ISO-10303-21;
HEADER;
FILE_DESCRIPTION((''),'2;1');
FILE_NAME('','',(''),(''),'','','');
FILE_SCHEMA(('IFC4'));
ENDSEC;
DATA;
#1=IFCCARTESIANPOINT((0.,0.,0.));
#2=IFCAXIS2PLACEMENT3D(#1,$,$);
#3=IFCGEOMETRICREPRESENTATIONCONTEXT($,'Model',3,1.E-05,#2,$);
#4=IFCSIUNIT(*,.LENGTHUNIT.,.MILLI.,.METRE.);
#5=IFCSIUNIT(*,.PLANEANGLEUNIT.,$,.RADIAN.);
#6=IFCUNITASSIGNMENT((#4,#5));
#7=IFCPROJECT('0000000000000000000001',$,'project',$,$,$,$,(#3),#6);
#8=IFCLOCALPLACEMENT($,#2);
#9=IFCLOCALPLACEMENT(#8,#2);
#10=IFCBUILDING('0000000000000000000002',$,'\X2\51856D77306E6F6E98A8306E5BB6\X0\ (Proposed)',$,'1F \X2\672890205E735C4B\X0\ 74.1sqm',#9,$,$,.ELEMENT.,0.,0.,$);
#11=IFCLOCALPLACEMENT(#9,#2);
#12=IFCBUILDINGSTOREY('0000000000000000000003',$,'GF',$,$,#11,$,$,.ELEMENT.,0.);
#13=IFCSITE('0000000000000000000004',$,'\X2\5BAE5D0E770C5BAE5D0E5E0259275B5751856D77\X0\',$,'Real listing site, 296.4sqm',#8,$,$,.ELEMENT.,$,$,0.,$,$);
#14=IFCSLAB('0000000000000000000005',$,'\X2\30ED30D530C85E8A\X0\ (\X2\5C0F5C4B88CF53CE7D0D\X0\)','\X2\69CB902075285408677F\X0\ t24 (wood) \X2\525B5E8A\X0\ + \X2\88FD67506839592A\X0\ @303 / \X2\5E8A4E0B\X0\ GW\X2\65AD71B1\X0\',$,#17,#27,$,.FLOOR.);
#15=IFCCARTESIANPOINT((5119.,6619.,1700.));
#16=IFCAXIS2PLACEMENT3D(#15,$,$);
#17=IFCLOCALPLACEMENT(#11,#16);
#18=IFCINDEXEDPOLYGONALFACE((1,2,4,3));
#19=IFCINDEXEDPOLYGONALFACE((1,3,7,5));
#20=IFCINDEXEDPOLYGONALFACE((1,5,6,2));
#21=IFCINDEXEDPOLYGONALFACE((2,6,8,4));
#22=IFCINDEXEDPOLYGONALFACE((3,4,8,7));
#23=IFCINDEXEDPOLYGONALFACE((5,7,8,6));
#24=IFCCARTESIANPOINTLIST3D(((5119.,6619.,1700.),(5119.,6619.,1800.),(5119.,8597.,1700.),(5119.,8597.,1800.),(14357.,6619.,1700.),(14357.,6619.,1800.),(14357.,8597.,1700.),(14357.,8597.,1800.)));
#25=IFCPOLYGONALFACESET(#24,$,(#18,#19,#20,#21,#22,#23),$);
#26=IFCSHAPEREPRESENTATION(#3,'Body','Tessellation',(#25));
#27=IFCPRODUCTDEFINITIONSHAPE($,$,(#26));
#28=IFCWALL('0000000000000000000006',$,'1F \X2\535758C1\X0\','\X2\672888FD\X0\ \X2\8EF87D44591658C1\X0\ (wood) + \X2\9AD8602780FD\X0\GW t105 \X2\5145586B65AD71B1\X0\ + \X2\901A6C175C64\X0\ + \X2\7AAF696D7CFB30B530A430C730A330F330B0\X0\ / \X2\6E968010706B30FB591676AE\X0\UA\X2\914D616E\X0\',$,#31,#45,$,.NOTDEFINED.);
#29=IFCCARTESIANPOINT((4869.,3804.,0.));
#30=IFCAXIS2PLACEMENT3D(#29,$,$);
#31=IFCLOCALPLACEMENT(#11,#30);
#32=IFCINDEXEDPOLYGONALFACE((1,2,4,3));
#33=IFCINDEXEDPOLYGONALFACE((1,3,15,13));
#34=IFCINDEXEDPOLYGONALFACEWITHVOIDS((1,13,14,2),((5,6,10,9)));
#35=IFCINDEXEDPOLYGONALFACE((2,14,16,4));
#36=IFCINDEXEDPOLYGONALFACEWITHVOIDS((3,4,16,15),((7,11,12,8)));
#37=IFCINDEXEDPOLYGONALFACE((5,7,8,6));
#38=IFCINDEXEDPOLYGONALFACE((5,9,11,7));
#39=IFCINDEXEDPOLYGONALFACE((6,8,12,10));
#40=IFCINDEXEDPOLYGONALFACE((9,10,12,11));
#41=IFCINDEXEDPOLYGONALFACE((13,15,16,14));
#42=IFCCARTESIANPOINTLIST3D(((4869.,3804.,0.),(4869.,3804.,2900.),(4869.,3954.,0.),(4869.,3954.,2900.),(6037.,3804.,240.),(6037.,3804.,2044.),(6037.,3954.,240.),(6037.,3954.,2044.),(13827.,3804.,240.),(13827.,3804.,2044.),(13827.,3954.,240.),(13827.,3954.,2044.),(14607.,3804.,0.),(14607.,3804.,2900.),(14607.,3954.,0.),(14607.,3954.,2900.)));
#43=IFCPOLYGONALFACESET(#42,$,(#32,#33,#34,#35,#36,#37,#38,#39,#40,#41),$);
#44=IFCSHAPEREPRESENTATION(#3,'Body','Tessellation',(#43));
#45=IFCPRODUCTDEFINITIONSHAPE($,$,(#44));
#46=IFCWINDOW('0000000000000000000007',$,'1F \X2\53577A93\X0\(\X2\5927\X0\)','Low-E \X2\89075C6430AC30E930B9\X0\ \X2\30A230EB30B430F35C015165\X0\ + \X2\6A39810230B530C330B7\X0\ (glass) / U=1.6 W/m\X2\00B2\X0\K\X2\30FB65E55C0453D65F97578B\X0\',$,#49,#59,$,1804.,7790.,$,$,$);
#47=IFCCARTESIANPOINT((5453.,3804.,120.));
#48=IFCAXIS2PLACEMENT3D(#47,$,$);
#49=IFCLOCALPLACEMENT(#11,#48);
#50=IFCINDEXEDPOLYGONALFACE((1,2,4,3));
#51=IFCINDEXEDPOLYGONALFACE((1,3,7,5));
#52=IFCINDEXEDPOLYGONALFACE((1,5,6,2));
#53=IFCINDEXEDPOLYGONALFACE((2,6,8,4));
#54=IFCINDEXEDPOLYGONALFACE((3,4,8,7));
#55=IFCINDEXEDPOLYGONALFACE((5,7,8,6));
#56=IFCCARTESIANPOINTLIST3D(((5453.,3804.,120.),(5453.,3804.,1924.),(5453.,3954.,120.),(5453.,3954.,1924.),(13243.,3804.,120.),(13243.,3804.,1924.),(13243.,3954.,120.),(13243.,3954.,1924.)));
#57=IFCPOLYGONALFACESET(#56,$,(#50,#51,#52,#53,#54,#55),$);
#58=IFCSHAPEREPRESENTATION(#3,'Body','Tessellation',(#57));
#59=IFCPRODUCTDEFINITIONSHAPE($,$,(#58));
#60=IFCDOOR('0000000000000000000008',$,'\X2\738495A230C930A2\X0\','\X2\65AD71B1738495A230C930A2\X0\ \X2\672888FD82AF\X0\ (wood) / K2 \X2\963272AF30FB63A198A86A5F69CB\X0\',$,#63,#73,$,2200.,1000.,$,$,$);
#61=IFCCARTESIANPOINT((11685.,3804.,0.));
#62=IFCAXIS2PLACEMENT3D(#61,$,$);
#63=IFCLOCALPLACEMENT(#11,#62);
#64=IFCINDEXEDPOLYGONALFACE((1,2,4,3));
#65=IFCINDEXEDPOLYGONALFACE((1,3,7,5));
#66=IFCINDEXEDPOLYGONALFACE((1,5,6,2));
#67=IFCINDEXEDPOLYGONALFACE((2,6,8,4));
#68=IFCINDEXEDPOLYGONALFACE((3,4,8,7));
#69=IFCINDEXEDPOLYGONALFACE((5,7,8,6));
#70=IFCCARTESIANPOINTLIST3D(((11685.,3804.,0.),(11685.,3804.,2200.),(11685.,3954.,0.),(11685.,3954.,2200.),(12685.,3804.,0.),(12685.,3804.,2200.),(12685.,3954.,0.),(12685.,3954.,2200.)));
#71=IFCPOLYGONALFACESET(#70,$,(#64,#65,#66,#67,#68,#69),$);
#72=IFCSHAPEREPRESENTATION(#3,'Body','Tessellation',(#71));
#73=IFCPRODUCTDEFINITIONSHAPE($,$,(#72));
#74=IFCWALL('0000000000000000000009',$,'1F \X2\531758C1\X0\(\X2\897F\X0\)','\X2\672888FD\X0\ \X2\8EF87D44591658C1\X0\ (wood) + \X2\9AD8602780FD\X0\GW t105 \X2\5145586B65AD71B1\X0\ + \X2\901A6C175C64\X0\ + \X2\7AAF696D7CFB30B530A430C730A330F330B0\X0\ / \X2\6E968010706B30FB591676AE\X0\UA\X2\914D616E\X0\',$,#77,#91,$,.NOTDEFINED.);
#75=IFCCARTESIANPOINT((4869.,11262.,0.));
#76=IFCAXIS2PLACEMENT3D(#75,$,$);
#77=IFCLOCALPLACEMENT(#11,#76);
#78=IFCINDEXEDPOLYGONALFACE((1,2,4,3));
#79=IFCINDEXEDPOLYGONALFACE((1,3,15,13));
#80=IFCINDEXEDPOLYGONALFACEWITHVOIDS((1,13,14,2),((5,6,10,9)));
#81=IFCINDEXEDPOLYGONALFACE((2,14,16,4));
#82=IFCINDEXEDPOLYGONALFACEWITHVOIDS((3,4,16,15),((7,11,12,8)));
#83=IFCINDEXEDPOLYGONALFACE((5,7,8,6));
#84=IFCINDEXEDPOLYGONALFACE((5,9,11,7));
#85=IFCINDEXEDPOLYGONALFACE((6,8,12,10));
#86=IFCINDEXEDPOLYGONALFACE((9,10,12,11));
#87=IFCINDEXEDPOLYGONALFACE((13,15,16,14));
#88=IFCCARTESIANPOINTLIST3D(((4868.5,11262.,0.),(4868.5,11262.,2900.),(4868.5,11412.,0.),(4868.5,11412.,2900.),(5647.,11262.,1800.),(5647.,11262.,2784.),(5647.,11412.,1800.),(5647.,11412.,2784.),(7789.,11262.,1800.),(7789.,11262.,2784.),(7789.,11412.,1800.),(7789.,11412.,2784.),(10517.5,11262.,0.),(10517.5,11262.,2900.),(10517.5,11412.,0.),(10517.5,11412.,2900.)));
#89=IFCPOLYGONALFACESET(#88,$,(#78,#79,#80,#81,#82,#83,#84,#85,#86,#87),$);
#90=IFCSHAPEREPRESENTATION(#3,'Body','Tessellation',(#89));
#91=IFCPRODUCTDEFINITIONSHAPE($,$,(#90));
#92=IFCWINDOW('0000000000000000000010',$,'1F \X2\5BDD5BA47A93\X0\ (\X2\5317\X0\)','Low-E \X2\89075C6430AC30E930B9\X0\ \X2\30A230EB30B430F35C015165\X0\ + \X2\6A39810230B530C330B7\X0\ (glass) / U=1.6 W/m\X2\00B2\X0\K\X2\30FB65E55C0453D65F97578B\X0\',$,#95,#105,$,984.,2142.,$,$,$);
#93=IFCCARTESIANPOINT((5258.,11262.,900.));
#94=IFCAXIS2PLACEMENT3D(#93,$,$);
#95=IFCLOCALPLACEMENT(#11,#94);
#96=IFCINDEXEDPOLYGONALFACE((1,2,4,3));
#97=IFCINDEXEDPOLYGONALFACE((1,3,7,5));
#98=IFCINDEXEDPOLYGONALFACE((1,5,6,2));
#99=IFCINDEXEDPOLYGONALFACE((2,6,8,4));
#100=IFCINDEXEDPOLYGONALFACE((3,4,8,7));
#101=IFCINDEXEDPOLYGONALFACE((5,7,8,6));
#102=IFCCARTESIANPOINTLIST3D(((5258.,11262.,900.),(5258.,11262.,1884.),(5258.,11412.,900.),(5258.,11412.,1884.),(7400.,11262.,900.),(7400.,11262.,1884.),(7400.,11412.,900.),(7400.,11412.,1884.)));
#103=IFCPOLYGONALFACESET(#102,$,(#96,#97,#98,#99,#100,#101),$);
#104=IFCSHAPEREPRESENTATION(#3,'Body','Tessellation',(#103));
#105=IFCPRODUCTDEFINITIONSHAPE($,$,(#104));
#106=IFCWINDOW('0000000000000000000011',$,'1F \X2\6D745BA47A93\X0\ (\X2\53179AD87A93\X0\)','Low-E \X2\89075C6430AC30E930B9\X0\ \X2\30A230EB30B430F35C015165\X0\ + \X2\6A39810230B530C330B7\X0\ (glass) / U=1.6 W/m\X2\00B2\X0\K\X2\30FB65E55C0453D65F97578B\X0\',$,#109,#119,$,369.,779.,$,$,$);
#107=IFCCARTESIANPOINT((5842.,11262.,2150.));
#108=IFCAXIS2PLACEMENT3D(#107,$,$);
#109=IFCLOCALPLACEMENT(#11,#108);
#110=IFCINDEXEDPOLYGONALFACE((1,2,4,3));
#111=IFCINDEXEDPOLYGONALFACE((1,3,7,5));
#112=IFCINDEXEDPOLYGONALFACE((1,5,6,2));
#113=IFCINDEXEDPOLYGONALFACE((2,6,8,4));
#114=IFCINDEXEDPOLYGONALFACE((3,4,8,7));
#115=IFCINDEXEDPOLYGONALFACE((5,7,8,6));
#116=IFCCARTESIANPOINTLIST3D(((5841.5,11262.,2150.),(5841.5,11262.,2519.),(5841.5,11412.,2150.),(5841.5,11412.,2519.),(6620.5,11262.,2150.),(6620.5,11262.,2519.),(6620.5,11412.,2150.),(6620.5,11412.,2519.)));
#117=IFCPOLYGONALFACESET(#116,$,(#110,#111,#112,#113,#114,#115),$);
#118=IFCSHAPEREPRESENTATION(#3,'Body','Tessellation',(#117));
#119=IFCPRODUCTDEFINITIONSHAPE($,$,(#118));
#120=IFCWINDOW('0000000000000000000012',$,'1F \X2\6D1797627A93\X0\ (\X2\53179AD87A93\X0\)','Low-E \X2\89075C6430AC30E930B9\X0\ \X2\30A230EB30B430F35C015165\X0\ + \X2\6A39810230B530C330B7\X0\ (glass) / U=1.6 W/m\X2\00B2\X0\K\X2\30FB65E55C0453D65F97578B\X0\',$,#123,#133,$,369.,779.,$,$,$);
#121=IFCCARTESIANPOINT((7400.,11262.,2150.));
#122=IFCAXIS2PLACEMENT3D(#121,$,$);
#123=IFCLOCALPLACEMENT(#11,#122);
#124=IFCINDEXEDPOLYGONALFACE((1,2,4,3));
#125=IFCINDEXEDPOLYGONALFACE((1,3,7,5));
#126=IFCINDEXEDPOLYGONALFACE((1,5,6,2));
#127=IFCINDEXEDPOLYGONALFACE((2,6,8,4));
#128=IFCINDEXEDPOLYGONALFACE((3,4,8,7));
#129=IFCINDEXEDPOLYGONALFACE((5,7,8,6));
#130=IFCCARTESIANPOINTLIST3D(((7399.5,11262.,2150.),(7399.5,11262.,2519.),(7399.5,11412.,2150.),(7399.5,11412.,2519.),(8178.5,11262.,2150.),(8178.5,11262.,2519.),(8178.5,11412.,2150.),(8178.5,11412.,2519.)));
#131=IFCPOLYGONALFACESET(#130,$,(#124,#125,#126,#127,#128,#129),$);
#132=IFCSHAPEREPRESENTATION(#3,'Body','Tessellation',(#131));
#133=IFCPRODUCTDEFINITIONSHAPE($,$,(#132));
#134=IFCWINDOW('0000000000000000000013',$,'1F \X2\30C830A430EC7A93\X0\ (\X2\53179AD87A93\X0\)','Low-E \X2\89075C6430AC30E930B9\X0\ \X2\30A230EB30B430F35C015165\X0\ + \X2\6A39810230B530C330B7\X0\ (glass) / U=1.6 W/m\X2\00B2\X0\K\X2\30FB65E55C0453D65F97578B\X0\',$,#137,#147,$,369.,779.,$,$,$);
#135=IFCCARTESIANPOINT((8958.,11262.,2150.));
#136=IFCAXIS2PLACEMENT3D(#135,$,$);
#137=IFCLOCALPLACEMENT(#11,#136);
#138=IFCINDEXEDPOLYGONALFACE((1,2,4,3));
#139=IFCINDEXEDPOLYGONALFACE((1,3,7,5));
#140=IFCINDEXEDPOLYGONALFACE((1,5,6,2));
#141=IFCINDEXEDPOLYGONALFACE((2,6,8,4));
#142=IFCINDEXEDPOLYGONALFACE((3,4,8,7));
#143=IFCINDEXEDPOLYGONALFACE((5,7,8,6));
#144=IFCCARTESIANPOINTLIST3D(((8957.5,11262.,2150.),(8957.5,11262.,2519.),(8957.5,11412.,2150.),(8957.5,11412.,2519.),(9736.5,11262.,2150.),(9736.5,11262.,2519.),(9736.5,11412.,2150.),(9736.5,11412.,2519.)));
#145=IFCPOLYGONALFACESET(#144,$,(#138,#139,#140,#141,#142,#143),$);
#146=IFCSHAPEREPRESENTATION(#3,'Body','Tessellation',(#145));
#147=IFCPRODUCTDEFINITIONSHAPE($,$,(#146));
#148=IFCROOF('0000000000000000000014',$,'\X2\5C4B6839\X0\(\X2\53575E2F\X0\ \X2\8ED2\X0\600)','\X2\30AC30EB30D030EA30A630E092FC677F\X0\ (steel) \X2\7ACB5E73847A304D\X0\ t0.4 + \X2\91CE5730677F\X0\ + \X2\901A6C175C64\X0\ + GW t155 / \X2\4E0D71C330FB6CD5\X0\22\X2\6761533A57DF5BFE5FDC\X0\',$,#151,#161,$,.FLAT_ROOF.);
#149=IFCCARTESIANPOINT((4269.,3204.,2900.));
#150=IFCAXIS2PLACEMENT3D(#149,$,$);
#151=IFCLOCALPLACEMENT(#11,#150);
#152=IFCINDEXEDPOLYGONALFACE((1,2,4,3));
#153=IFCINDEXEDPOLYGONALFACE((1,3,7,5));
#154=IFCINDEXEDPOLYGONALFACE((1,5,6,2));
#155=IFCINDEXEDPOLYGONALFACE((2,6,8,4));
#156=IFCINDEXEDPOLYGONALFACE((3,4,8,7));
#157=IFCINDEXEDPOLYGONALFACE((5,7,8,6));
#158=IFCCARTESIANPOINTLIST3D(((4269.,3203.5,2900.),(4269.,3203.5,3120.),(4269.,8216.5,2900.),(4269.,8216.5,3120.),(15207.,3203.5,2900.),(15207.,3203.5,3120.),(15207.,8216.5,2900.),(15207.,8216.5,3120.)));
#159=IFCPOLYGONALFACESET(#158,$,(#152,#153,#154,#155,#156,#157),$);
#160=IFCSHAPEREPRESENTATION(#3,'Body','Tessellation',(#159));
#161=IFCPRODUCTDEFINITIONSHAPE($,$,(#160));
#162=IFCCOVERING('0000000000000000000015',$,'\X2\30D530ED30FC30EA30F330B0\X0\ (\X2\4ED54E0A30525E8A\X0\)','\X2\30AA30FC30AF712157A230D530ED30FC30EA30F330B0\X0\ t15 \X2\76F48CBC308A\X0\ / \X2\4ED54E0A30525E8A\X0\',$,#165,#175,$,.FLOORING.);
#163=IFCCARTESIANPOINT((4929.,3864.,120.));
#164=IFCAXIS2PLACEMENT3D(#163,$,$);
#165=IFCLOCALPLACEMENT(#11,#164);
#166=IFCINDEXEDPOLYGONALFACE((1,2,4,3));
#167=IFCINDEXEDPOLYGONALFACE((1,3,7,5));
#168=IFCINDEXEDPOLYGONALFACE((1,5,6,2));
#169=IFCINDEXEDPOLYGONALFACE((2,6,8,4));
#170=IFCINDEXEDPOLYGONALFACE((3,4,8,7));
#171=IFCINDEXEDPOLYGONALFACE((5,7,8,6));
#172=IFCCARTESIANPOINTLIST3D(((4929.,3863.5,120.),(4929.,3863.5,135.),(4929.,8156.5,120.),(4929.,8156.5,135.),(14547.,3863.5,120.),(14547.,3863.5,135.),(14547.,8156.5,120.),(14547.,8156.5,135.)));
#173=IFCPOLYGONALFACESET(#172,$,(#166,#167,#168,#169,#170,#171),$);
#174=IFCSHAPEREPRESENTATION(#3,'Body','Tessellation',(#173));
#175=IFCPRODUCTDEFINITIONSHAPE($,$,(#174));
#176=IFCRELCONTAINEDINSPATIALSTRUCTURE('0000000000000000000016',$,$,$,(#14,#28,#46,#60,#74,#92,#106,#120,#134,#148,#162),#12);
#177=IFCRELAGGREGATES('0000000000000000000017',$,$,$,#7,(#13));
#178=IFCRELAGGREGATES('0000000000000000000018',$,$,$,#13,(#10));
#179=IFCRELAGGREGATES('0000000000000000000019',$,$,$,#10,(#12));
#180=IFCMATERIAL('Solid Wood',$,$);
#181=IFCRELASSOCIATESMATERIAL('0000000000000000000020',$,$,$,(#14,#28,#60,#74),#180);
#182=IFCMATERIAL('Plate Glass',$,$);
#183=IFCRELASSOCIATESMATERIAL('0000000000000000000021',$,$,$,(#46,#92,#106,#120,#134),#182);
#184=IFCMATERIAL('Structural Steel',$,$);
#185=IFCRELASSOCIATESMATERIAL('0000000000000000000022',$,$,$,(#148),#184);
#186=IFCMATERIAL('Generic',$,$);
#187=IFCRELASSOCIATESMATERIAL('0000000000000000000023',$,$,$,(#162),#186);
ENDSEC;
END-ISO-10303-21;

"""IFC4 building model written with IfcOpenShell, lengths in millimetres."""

from ifc_helpers import new_model, si_unit, frame, frame_2d, origin, place, context, project, spatial, rectangle, extrude, material, element, fill, save


model = new_model("IFC4")

# Units and contexts
model_context = context("Model", 3, precision=1e-05, world=origin())
ifc_project = project(units=[si_unit("LENGTHUNIT", "METRE", prefix="MILLI"), si_unit("PLANEANGLEUNIT", "RADIAN")], contexts=[model_context])

# Site, building, storey
site_placement = place(None, origin())
site = spatial("IfcSite", under=ifc_project, at=site_placement, Name="宮崎県宮崎市大字内海", ObjectType="Real listing site, 296.4sqm", CompositionType="ELEMENT", RefElevation=0.0)
building_placement = place(site_placement, origin())
building = spatial("IfcBuilding", under=site, at=building_placement, Name="内海の潮風の家 (Proposed)", ObjectType="1F 木造平屋 74.1sqm", CompositionType="ELEMENT", ElevationOfRefHeight=0.0, ElevationOfTerrain=0.0)
storey_placement = place(building_placement, origin())
storey = spatial("IfcBuildingStorey", under=building, at=storey_placement, Name="GF", CompositionType="ELEMENT", Elevation=0.0)

# Slab
ifc_material_1 = material(Name="Solid Wood")
slab_1_placement = place(storey_placement, frame((5119.0, 6619.0, 1700.0)))
element("IfcSlab", 1, at=slab_1_placement, inside=storey, material=ifc_material_1, Name="ロフト床 (小屋裏収納)", Description="構造用合板 t24 (wood) 剛床 + 製材根太 @303 / 床下 GW断熱", PredefinedType="FLOOR", context=model_context, shape_type="SweptSolid", body=[
    extrude(rectangle(XDim=9238.0, YDim=1978.0, at=frame_2d((4619.0, 989.0))), frame((5119.0, 6619.0, 1700.0)), (0.0, 0.0, 1.0), 100.0),
])

# Wall, openings, window, door
wall_1_placement = place(storey_placement, frame((4869.0, 3804.0, 0.0)))
wall_1 = element("IfcWall", 2, at=wall_1_placement, inside=storey, material=ifc_material_1, Name="1F 南壁", Description="木製 軸組外壁 (wood) + 高性能GW t105 充填断熱 + 通気層 + 窯業系サイディング / 準耐火・外皮UA配慮", PredefinedType="NOTDEFINED", context=model_context, shape_type="SweptSolid", body=[
    extrude(rectangle(XDim=9738.0, YDim=150.0, at=frame_2d((4869.0, 75.0))), frame((4869.0, 3804.0, 0.0)), (0.0, 0.0, 1.0), 2900.0),
])
opening_1_placement = place(storey_placement, frame((5453.0, 3804.0, 120.0)))
opening_1 = element("IfcOpeningElement", 3, at=opening_1_placement, cuts=wall_1, PredefinedType="NOTDEFINED", context=model_context, shape_type="SweptSolid", body=[
    extrude(rectangle(XDim=7790.0, YDim=150.0, at=frame_2d((3895.0, 75.0))), frame((5453.0, 3804.0, 120.0)), (0.0, 0.0, 1.0), 1804.0),
])
opening_2_placement = place(storey_placement, frame((11685.0, 3804.0, 0.0)))
opening_2 = element("IfcOpeningElement", 4, at=opening_2_placement, cuts=wall_1, PredefinedType="NOTDEFINED", context=model_context, shape_type="SweptSolid", body=[
    extrude(rectangle(XDim=1000.0, YDim=150.0, at=frame_2d((500.0, 75.0))), frame((11685.0, 3804.0, 0.0)), (0.0, 0.0, 1.0), 2200.0),
])
ifc_material_2 = material(Name="Plate Glass")
window_1_placement = place(storey_placement, frame((5453.0, 3804.0, 120.0)))
window_1 = element("IfcWindow", 5, at=window_1_placement, inside=storey, material=ifc_material_2, Name="1F 南窓(大)", Description="Low-E 複層ガラス アルゴン封入 + 樹脂サッシ (glass) / U=1.6 W/m²K・日射取得型", OverallHeight=1804.0, OverallWidth=7790.0, context=model_context, shape_type="SweptSolid", body=[
    extrude(rectangle(XDim=7790.0, YDim=150.0, at=frame_2d((3895.0, 75.0))), frame((5453.0, 3804.0, 120.0)), (0.0, 0.0, 1.0), 1804.0),
])
fill(opening_1, window_1)
door_placement = place(storey_placement, frame((11685.0, 3804.0, 0.0)))
door = element("IfcDoor", 6, at=door_placement, inside=storey, material=ifc_material_1, Name="玄関ドア", Description="断熱玄関ドア 木製芯 (wood) / K2 防犯・採風機構", OverallHeight=2200.0, OverallWidth=1000.0, context=model_context, shape_type="SweptSolid", body=[
    extrude(rectangle(XDim=1000.0, YDim=150.0, at=frame_2d((500.0, 75.0))), frame((11685.0, 3804.0, 0.0)), (0.0, 0.0, 1.0), 2200.0),
])
fill(opening_2, door)

# Wall, openings, windows
wall_2_placement = place(storey_placement, frame((4869.0, 11262.0, 0.0)))
wall_2 = element("IfcWall", 7, at=wall_2_placement, inside=storey, material=ifc_material_1, Name="1F 北壁(西)", Description="木製 軸組外壁 (wood) + 高性能GW t105 充填断熱 + 通気層 + 窯業系サイディング / 準耐火・外皮UA配慮", PredefinedType="NOTDEFINED", context=model_context, shape_type="SweptSolid", body=[
    extrude(rectangle(XDim=5649.0, YDim=150.0, at=frame_2d((2824.0, 75.0))), frame((4869.0, 11262.0, 0.0)), (0.0, 0.0, 1.0), 2900.0),
])
opening_3_placement = place(storey_placement, frame((5258.0, 11262.0, 900.0)))
opening_3 = element("IfcOpeningElement", 8, at=opening_3_placement, cuts=wall_2, PredefinedType="NOTDEFINED", context=model_context, shape_type="SweptSolid", body=[
    extrude(rectangle(XDim=2142.0, YDim=150.0, at=frame_2d((1071.0, 75.0))), frame((5258.0, 11262.0, 900.0)), (0.0, 0.0, 1.0), 984.0),
])
opening_4_placement = place(storey_placement, frame((5842.0, 11262.0, 2150.0)))
opening_4 = element("IfcOpeningElement", 9, at=opening_4_placement, cuts=wall_2, PredefinedType="NOTDEFINED", context=model_context, shape_type="SweptSolid", body=[
    extrude(rectangle(XDim=779.0, YDim=150.0, at=frame_2d((389.0, 75.0))), frame((5842.0, 11262.0, 2150.0)), (0.0, 0.0, 1.0), 369.0),
])
opening_5_placement = place(storey_placement, frame((7400.0, 11262.0, 2150.0)))
opening_5 = element("IfcOpeningElement", 10, at=opening_5_placement, cuts=wall_2, PredefinedType="NOTDEFINED", context=model_context, shape_type="SweptSolid", body=[
    extrude(rectangle(XDim=779.0, YDim=150.0, at=frame_2d((389.0, 75.0))), frame((7400.0, 11262.0, 2150.0)), (0.0, 0.0, 1.0), 369.0),
])
opening_6_placement = place(storey_placement, frame((8958.0, 11262.0, 2150.0)))
opening_6 = element("IfcOpeningElement", 11, at=opening_6_placement, cuts=wall_2, PredefinedType="NOTDEFINED", context=model_context, shape_type="SweptSolid", body=[
    extrude(rectangle(XDim=779.0, YDim=150.0, at=frame_2d((389.0, 75.0))), frame((8958.0, 11262.0, 2150.0)), (0.0, 0.0, 1.0), 369.0),
])
window_2_placement = place(storey_placement, frame((5258.0, 11262.0, 900.0)))
window_2 = element("IfcWindow", 12, at=window_2_placement, inside=storey, material=ifc_material_2, Name="1F 寝室窓 (北)", Description="Low-E 複層ガラス アルゴン封入 + 樹脂サッシ (glass) / U=1.6 W/m²K・日射取得型", OverallHeight=984.0, OverallWidth=2142.0, context=model_context, shape_type="SweptSolid", body=[
    extrude(rectangle(XDim=2142.0, YDim=150.0, at=frame_2d((1071.0, 75.0))), frame((5258.0, 11262.0, 900.0)), (0.0, 0.0, 1.0), 984.0),
])
fill(opening_3, window_2)
window_3_placement = place(storey_placement, frame((5842.0, 11262.0, 2150.0)))
window_3 = element("IfcWindow", 13, at=window_3_placement, inside=storey, material=ifc_material_2, Name="1F 浴室窓 (北高窓)", Description="Low-E 複層ガラス アルゴン封入 + 樹脂サッシ (glass) / U=1.6 W/m²K・日射取得型", OverallHeight=369.0, OverallWidth=779.0, context=model_context, shape_type="SweptSolid", body=[
    extrude(rectangle(XDim=779.0, YDim=150.0, at=frame_2d((389.0, 75.0))), frame((5842.0, 11262.0, 2150.0)), (0.0, 0.0, 1.0), 369.0),
])
fill(opening_4, window_3)
window_4_placement = place(storey_placement, frame((7400.0, 11262.0, 2150.0)))
window_4 = element("IfcWindow", 14, at=window_4_placement, inside=storey, material=ifc_material_2, Name="1F 洗面窓 (北高窓)", Description="Low-E 複層ガラス アルゴン封入 + 樹脂サッシ (glass) / U=1.6 W/m²K・日射取得型", OverallHeight=369.0, OverallWidth=779.0, context=model_context, shape_type="SweptSolid", body=[
    extrude(rectangle(XDim=779.0, YDim=150.0, at=frame_2d((389.0, 75.0))), frame((7400.0, 11262.0, 2150.0)), (0.0, 0.0, 1.0), 369.0),
])
fill(opening_5, window_4)
window_5_placement = place(storey_placement, frame((8958.0, 11262.0, 2150.0)))
window_5 = element("IfcWindow", 15, at=window_5_placement, inside=storey, material=ifc_material_2, Name="1F トイレ窓 (北高窓)", Description="Low-E 複層ガラス アルゴン封入 + 樹脂サッシ (glass) / U=1.6 W/m²K・日射取得型", OverallHeight=369.0, OverallWidth=779.0, context=model_context, shape_type="SweptSolid", body=[
    extrude(rectangle(XDim=779.0, YDim=150.0, at=frame_2d((389.0, 75.0))), frame((8958.0, 11262.0, 2150.0)), (0.0, 0.0, 1.0), 369.0),
])
fill(opening_6, window_5)

# Roof
ifc_material_3 = material(Name="Structural Steel")
roof_1_placement = place(storey_placement, frame((4269.0, 3204.0, 2900.0)))
element("IfcRoof", 16, at=roof_1_placement, inside=storey, material=ifc_material_3, Name="屋根(南帯 軒600)", Description="ガルバリウム鋼板 (steel) 立平葺き t0.4 + 野地板 + 通気層 + GW t155 / 不燃・法22条区域対応", PredefinedType="FLAT_ROOF", context=model_context, shape_type="SweptSolid", body=[
    extrude(rectangle(XDim=10938.0, YDim=5013.0, at=frame_2d((5469.0, 2506.0))), frame((4269.0, 3204.0, 2900.0)), (0.0, 0.0, 1.0), 220.0),
])

# Covering
ifc_material_4 = material(Name="Generic")
covering_1_placement = place(storey_placement, frame((4929.0, 3864.0, 120.0)))
element("IfcCovering", 17, at=covering_1_placement, inside=storey, material=ifc_material_4, Name="フローリング (仕上げ床)", Description="オーク無垢フローリング t15 直貼り / 仕上げ床", PredefinedType="FLOORING", context=model_context, shape_type="SweptSolid", body=[
    extrude(rectangle(XDim=9618.0, YDim=4293.0, at=frame_2d((4809.0, 2146.0))), frame((4929.0, 3864.0, 120.0)), (0.0, 0.0, 1.0), 15.0),
])

save(model, "model.ifc")
